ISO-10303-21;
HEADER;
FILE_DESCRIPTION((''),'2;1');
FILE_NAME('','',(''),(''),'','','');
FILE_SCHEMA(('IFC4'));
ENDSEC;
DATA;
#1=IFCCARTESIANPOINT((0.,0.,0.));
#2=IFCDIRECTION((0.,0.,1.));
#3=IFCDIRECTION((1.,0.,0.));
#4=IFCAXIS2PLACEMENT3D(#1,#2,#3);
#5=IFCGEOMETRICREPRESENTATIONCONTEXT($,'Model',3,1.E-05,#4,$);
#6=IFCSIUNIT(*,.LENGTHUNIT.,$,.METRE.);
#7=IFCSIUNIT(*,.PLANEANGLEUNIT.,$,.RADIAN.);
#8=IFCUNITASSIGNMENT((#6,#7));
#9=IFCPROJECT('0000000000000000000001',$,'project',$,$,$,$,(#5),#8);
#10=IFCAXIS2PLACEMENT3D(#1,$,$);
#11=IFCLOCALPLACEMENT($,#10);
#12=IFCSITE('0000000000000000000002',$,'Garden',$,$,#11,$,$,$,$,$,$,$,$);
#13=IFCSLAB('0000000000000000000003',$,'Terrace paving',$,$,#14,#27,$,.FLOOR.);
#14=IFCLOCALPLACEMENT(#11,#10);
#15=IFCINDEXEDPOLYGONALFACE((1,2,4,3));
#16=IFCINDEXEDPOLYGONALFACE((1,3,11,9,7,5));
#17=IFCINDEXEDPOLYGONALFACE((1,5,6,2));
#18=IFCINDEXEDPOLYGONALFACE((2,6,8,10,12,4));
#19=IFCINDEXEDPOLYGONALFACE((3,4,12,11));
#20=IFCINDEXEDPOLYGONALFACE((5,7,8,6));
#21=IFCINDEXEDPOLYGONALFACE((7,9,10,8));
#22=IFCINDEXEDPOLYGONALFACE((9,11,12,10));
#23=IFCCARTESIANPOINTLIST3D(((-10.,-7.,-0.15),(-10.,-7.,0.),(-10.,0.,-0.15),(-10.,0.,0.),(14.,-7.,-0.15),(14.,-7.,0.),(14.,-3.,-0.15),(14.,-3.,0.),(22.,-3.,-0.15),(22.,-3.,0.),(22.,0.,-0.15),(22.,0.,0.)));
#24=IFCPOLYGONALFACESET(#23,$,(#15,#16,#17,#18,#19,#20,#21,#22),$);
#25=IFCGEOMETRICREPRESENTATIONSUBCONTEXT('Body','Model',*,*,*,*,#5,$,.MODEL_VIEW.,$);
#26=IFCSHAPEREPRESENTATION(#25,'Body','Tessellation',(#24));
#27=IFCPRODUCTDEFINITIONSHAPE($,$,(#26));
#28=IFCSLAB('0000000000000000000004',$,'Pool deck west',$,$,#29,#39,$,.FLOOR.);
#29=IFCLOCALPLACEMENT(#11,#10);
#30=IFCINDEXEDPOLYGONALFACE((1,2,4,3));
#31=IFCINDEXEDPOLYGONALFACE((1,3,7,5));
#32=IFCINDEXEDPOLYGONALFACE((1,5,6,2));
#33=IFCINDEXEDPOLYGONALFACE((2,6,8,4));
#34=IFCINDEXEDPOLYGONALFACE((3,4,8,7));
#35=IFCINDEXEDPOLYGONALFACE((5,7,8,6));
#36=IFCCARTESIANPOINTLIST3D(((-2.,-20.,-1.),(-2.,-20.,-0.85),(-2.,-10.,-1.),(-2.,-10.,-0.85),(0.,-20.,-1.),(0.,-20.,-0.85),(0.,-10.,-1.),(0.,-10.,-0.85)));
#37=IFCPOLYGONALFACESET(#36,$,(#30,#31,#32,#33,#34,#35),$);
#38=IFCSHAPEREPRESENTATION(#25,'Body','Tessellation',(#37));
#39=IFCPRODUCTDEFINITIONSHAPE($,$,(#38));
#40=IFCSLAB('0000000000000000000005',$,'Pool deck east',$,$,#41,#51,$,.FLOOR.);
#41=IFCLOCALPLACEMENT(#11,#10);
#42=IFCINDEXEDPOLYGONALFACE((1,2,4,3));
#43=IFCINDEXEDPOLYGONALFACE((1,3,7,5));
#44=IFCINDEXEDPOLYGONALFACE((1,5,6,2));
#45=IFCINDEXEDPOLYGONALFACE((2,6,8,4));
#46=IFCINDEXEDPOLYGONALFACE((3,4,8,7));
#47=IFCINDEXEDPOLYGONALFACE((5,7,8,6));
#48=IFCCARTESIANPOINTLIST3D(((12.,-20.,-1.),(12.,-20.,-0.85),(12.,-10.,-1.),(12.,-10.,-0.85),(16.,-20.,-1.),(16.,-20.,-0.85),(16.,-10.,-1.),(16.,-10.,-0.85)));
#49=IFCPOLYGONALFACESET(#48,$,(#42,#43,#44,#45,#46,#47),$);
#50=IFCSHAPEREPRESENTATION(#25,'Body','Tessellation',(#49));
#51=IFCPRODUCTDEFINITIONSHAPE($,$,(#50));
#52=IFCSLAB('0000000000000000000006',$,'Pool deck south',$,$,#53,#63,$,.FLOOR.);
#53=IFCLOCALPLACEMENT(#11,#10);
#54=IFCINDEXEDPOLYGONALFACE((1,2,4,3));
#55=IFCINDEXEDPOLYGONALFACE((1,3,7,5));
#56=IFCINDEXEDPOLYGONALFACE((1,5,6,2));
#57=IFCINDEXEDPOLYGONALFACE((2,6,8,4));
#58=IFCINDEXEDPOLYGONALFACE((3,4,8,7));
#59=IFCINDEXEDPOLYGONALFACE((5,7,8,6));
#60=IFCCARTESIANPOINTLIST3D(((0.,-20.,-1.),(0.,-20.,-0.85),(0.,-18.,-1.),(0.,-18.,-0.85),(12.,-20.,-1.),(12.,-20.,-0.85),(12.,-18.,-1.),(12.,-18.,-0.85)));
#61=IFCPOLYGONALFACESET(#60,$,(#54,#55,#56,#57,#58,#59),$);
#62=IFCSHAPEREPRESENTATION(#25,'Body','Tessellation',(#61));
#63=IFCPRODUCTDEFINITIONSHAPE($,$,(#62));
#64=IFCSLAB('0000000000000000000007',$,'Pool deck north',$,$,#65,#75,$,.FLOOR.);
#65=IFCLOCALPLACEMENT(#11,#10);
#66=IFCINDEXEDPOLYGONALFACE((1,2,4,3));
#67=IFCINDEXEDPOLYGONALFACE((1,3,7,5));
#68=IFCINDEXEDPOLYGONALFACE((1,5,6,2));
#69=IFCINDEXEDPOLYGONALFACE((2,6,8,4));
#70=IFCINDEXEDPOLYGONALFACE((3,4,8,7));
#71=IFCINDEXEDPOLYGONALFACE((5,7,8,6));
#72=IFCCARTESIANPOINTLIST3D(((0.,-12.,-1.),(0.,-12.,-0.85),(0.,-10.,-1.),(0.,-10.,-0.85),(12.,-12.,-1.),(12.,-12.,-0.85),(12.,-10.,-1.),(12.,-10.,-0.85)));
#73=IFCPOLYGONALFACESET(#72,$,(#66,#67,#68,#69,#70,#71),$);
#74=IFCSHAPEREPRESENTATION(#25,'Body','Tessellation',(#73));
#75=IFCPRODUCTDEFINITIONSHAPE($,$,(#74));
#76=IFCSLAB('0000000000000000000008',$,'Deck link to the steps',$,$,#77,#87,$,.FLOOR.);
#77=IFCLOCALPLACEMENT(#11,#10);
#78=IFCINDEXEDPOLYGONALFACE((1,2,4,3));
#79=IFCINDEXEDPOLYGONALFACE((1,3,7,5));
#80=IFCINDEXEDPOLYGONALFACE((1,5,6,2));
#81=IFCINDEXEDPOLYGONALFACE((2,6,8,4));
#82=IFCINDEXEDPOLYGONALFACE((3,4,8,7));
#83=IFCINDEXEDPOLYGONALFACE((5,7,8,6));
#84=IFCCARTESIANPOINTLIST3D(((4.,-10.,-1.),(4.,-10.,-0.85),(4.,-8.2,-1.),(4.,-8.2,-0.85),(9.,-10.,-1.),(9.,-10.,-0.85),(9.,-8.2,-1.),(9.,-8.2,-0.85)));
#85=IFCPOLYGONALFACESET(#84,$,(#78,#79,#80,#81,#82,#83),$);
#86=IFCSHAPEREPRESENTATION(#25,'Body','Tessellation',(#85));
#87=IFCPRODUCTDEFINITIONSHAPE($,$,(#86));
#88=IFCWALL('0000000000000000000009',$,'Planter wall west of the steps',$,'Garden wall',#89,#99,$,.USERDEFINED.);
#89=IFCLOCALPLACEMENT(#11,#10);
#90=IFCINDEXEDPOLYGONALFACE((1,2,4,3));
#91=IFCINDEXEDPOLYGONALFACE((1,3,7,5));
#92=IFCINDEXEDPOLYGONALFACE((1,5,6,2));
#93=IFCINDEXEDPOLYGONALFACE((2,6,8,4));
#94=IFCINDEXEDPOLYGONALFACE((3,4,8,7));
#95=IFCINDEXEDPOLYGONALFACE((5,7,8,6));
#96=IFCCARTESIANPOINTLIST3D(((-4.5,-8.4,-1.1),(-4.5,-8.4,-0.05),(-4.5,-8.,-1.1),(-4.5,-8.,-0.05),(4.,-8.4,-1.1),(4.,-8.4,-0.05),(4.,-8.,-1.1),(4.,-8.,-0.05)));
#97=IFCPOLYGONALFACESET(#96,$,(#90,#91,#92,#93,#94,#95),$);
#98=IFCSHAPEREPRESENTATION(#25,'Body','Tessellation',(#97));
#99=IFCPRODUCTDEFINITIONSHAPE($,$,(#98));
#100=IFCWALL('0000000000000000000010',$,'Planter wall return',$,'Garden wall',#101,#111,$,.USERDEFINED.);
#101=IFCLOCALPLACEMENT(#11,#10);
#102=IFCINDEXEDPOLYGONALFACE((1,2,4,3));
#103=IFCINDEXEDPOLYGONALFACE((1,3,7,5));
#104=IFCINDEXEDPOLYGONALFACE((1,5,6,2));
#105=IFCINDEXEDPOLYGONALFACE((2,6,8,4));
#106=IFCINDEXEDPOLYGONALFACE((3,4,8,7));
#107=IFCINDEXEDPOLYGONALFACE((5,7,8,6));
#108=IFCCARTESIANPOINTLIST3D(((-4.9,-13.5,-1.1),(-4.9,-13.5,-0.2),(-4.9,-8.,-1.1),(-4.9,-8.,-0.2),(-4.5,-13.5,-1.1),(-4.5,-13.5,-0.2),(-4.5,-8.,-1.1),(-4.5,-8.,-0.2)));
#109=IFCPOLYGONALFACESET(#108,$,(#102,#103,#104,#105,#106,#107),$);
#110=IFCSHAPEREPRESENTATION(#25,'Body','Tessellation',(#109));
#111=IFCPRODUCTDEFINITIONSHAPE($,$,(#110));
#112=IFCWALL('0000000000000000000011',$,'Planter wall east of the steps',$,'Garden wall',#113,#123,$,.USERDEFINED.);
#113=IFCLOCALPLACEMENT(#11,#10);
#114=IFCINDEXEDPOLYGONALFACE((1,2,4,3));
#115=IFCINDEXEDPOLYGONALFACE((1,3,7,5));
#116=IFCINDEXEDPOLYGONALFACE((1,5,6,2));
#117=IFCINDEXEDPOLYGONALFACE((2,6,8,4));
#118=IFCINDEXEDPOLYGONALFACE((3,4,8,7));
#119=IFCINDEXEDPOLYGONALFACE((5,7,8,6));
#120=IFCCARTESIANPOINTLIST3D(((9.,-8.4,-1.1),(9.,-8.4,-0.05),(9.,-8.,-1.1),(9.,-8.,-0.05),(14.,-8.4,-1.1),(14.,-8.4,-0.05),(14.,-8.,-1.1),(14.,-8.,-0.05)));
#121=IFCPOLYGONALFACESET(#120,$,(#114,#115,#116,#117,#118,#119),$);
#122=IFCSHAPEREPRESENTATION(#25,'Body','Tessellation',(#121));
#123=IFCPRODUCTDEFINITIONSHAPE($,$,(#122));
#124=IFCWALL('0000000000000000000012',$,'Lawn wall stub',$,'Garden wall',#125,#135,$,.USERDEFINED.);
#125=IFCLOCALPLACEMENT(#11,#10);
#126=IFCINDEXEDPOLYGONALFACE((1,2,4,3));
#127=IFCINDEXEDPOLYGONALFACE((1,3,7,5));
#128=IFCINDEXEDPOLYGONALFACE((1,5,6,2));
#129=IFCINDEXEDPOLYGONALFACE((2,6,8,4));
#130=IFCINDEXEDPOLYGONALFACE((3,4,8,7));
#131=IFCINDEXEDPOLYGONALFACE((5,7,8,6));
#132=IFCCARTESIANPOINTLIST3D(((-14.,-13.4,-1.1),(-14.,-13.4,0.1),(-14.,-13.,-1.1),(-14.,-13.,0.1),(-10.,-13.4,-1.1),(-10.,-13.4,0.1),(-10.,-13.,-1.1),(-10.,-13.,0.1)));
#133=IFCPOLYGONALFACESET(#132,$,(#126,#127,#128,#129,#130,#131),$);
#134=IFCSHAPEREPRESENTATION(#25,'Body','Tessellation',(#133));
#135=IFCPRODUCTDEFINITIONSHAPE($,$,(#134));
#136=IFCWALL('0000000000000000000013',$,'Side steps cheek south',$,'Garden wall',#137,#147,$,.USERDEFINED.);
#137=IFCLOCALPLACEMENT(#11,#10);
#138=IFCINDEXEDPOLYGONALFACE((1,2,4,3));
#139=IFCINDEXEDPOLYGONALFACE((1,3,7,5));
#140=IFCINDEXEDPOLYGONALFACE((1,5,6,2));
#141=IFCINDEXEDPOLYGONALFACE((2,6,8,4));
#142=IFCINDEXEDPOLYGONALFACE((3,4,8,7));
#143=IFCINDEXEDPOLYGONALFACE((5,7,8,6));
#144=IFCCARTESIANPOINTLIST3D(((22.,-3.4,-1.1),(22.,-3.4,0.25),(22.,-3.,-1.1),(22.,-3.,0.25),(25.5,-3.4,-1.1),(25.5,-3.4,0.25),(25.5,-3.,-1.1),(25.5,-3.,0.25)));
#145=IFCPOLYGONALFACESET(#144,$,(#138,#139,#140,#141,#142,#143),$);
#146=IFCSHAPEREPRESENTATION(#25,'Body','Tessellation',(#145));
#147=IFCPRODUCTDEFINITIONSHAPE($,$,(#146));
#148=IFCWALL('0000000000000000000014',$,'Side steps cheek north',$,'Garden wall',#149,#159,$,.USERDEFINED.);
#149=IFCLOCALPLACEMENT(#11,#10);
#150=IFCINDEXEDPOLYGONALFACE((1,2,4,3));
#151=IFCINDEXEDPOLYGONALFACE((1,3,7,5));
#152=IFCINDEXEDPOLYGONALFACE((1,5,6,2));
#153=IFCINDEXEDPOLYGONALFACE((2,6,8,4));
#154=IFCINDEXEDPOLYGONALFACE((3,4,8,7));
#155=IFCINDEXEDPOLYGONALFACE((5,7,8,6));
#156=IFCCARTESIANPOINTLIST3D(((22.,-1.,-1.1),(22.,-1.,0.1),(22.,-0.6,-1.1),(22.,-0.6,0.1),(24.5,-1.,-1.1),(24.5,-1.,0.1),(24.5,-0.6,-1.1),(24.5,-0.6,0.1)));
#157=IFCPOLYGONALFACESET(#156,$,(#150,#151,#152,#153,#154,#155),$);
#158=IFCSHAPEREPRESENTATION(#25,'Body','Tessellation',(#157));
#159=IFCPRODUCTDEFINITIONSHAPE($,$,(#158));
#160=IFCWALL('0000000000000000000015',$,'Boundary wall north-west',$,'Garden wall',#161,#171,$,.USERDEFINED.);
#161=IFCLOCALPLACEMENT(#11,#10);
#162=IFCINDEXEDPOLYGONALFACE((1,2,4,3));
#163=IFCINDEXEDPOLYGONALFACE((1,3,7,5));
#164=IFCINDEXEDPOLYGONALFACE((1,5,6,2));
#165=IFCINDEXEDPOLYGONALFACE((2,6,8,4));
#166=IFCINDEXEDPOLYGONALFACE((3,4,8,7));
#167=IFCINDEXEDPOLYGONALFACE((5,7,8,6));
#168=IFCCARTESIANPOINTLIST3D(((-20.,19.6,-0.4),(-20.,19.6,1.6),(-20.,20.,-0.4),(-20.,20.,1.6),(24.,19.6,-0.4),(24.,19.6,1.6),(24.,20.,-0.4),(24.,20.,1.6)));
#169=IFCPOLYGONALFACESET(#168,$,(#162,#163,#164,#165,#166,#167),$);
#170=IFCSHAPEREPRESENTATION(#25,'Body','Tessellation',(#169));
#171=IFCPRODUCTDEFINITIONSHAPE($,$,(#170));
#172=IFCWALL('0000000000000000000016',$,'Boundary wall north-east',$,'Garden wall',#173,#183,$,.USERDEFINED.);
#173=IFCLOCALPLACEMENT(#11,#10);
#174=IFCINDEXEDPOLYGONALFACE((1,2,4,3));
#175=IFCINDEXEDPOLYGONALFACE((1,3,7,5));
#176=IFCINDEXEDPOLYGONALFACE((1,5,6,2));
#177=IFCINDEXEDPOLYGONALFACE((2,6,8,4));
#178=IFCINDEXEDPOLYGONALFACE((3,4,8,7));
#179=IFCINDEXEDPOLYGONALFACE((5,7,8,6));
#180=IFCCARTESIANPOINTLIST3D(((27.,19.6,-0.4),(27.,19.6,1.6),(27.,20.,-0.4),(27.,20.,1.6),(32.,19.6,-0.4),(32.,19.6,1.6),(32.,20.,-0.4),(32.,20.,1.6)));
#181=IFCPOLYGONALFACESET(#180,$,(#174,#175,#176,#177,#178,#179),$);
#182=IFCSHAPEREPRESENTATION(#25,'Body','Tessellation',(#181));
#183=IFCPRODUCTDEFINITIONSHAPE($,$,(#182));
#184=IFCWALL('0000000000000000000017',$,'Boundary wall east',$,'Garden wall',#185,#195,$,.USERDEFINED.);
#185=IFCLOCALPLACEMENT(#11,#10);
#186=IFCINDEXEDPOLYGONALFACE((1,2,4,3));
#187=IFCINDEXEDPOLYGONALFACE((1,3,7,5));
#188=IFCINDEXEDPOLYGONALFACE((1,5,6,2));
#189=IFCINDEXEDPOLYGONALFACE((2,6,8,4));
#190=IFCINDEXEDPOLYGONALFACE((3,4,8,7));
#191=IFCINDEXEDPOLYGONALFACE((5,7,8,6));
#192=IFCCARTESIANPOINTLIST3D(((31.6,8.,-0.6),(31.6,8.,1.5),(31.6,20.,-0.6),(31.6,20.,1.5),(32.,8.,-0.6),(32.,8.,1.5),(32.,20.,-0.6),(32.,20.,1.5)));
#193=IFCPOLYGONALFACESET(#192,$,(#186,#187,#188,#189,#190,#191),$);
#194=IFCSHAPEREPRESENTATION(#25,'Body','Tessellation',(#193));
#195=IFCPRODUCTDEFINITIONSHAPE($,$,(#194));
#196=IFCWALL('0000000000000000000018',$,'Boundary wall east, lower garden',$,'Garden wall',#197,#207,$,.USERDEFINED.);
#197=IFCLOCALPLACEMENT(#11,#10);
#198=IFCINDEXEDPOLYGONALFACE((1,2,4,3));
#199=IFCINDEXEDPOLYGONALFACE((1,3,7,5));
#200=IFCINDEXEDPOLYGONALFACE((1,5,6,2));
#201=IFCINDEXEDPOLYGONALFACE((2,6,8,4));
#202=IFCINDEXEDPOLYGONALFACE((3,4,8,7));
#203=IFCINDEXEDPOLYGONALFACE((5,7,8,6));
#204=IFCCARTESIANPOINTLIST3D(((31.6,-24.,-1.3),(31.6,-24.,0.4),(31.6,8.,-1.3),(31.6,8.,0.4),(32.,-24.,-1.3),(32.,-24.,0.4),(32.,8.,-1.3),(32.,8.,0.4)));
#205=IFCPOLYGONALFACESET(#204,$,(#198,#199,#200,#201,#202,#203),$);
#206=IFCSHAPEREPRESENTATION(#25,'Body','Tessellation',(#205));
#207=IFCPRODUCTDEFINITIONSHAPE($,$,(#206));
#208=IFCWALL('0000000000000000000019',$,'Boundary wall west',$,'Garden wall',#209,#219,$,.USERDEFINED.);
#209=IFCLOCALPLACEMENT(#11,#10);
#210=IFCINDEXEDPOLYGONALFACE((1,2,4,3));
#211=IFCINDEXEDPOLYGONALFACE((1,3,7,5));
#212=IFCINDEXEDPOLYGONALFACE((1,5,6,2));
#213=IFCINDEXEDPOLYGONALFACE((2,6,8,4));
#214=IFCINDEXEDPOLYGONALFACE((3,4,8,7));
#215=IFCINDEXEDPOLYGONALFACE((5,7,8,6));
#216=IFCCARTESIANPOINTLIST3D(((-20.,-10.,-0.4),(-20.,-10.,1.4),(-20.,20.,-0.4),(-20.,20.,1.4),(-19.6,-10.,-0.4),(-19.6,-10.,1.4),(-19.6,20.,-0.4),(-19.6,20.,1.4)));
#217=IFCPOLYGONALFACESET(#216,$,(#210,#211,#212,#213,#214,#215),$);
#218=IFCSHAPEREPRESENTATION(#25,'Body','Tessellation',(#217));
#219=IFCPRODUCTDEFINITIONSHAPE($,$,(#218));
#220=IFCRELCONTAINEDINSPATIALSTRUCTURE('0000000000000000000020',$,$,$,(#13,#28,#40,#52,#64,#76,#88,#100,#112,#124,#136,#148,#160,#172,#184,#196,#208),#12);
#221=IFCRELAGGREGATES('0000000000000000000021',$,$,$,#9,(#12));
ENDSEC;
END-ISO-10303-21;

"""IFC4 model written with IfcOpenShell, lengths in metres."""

from ifc_helpers import new_model, si_unit, frame, frame_2d, origin, origin_with_axes, place, context, subcontext, project, spatial, polyline, rectangle, outline, extrude, element, save


model = new_model("IFC4")

# Units and contexts
model_context = context("Model", 3, precision=1e-05, world=origin_with_axes())
body_context = subcontext(model_context, "Body", "Model", "MODEL_VIEW")
ifc_project = project(units=[si_unit("LENGTHUNIT", "METRE"), si_unit("PLANEANGLEUNIT", "RADIAN")], contexts=[model_context])

# Site
site_placement = place(None, origin())
site = spatial("IfcSite", under=ifc_project, at=site_placement, Name="Garden")

# Slabs
slab_1_placement = place(site_placement, frame((0.0, 0.0, -0.15)))
element("IfcSlab", 1, at=slab_1_placement, inside=site, Name="Terrace paving", PredefinedType="FLOOR", context=body_context, shape_type="SweptSolid", body=[
    extrude(outline(polyline([(-10.0, -7.0), (14.0, -7.0), (14.0, -3.0), (22.0, -3.0), (22.0, 0.0), (-10.0, 0.0), (-10.0, -7.0)])), origin(), (0.0, 0.0, 1.0), 0.15),
])
slab_2_placement = place(site_placement, frame((0.0, 0.0, -1.0)))
element("IfcSlab", 2, at=slab_2_placement, inside=site, Name="Pool deck west", PredefinedType="FLOOR", context=body_context, shape_type="SweptSolid", body=[
    extrude(outline(polyline([(-2.0, -20.0), (0.0, -20.0), (0.0, -10.0), (-2.0, -10.0), (-2.0, -20.0)])), origin(), (0.0, 0.0, 1.0), 0.15),
])
slab_3_placement = place(site_placement, frame((0.0, 0.0, -1.0)))
element("IfcSlab", 3, at=slab_3_placement, inside=site, Name="Pool deck east", PredefinedType="FLOOR", context=body_context, shape_type="SweptSolid", body=[
    extrude(outline(polyline([(12.0, -20.0), (16.0, -20.0), (16.0, -10.0), (12.0, -10.0), (12.0, -20.0)])), origin(), (0.0, 0.0, 1.0), 0.15),
])
slab_4_placement = place(site_placement, frame((0.0, 0.0, -1.0)))
element("IfcSlab", 4, at=slab_4_placement, inside=site, Name="Pool deck south", PredefinedType="FLOOR", context=body_context, shape_type="SweptSolid", body=[
    extrude(outline(polyline([(0.0, -20.0), (12.0, -20.0), (12.0, -18.0), (0.0, -18.0), (0.0, -20.0)])), origin(), (0.0, 0.0, 1.0), 0.15),
])
slab_5_placement = place(site_placement, frame((0.0, 0.0, -1.0)))
element("IfcSlab", 5, at=slab_5_placement, inside=site, Name="Pool deck north", PredefinedType="FLOOR", context=body_context, shape_type="SweptSolid", body=[
    extrude(outline(polyline([(0.0, -12.0), (12.0, -12.0), (12.0, -10.0), (0.0, -10.0), (0.0, -12.0)])), origin(), (0.0, 0.0, 1.0), 0.15),
])
slab_6_placement = place(site_placement, frame((0.0, 0.0, -1.0)))
element("IfcSlab", 6, at=slab_6_placement, inside=site, Name="Deck link to the steps", PredefinedType="FLOOR", context=body_context, shape_type="SweptSolid", body=[
    extrude(outline(polyline([(4.0, -10.0), (9.0, -10.0), (9.0, -8.2), (4.0, -8.2), (4.0, -10.0)])), origin(), (0.0, 0.0, 1.0), 0.15),
])

# Walls
wall_1_placement = place(site_placement, origin())
element("IfcWall", 7, at=wall_1_placement, inside=site, Name="Planter wall west of the steps", ObjectType="Garden wall", PredefinedType="USERDEFINED", context=body_context, shape_type="SweptSolid", body=[
    extrude(rectangle(XDim=8.5, YDim=0.4, at=frame_2d((4.25, 0.2))), frame((-4.5, -8.4, -1.1)), (0.0, 0.0, 1.0), 1.05),
])
wall_2_placement = place(site_placement, origin())
element("IfcWall", 8, at=wall_2_placement, inside=site, Name="Planter wall return", ObjectType="Garden wall", PredefinedType="USERDEFINED", context=body_context, shape_type="SweptSolid", body=[
    extrude(rectangle(XDim=0.4, YDim=5.5, at=frame_2d((0.2, 2.75))), frame((-4.9, -13.5, -1.1)), (0.0, 0.0, 1.0), 0.9),
])
wall_3_placement = place(site_placement, origin())
element("IfcWall", 9, at=wall_3_placement, inside=site, Name="Planter wall east of the steps", ObjectType="Garden wall", PredefinedType="USERDEFINED", context=body_context, shape_type="SweptSolid", body=[
    extrude(rectangle(XDim=5.0, YDim=0.4, at=frame_2d((2.5, 0.2))), frame((9.0, -8.4, -1.1)), (0.0, 0.0, 1.0), 1.05),
])
wall_4_placement = place(site_placement, origin())
element("IfcWall", 10, at=wall_4_placement, inside=site, Name="Lawn wall stub", ObjectType="Garden wall", PredefinedType="USERDEFINED", context=body_context, shape_type="SweptSolid", body=[
    extrude(rectangle(XDim=4.0, YDim=0.4, at=frame_2d((2.0, 0.2))), frame((-14.0, -13.4, -1.1)), (0.0, 0.0, 1.0), 1.2),
])
wall_5_placement = place(site_placement, origin())
element("IfcWall", 11, at=wall_5_placement, inside=site, Name="Side steps cheek south", ObjectType="Garden wall", PredefinedType="USERDEFINED", context=body_context, shape_type="SweptSolid", body=[
    extrude(rectangle(XDim=3.5, YDim=0.4, at=frame_2d((1.75, 0.2))), frame((22.0, -3.4, -1.1)), (0.0, 0.0, 1.0), 1.35),
])
wall_6_placement = place(site_placement, origin())
element("IfcWall", 12, at=wall_6_placement, inside=site, Name="Side steps cheek north", ObjectType="Garden wall", PredefinedType="USERDEFINED", context=body_context, shape_type="SweptSolid", body=[
    extrude(rectangle(XDim=2.5, YDim=0.4, at=frame_2d((1.25, 0.2))), frame((22.0, -1.0, -1.1)), (0.0, 0.0, 1.0), 1.2),
])
wall_7_placement = place(site_placement, origin())
element("IfcWall", 13, at=wall_7_placement, inside=site, Name="Boundary wall north-west", ObjectType="Garden wall", PredefinedType="USERDEFINED", context=body_context, shape_type="SweptSolid", body=[
    extrude(rectangle(XDim=44.0, YDim=0.4, at=frame_2d((22.0, 0.2))), frame((-20.0, 19.6, -0.4)), (0.0, 0.0, 1.0), 2.0),
])
wall_8_placement = place(site_placement, origin())
element("IfcWall", 14, at=wall_8_placement, inside=site, Name="Boundary wall north-east", ObjectType="Garden wall", PredefinedType="USERDEFINED", context=body_context, shape_type="SweptSolid", body=[
    extrude(rectangle(XDim=5.0, YDim=0.4, at=frame_2d((2.5, 0.2))), frame((27.0, 19.6, -0.4)), (0.0, 0.0, 1.0), 2.0),
])
wall_9_placement = place(site_placement, origin())
element("IfcWall", 15, at=wall_9_placement, inside=site, Name="Boundary wall east", ObjectType="Garden wall", PredefinedType="USERDEFINED", context=body_context, shape_type="SweptSolid", body=[
    extrude(rectangle(XDim=0.4, YDim=12.0, at=frame_2d((0.2, 6.0))), frame((31.6, 8.0, -0.6)), (0.0, 0.0, 1.0), 2.1),
])
wall_10_placement = place(site_placement, origin())
element("IfcWall", 16, at=wall_10_placement, inside=site, Name="Boundary wall east, lower garden", ObjectType="Garden wall", PredefinedType="USERDEFINED", context=body_context, shape_type="SweptSolid", body=[
    extrude(rectangle(XDim=0.4, YDim=32.0, at=frame_2d((0.2, 16.0))), frame((31.6, -24.0, -1.3)), (0.0, 0.0, 1.0), 1.7),
])
wall_11_placement = place(site_placement, origin())
element("IfcWall", 17, at=wall_11_placement, inside=site, Name="Boundary wall west", ObjectType="Garden wall", PredefinedType="USERDEFINED", context=body_context, shape_type="SweptSolid", body=[
    extrude(rectangle(XDim=0.4, YDim=30.0, at=frame_2d((0.2, 15.0))), frame((-20.0, -10.0, -0.4)), (0.0, 0.0, 1.0), 1.8),
])

save(model, "model.ifc")
